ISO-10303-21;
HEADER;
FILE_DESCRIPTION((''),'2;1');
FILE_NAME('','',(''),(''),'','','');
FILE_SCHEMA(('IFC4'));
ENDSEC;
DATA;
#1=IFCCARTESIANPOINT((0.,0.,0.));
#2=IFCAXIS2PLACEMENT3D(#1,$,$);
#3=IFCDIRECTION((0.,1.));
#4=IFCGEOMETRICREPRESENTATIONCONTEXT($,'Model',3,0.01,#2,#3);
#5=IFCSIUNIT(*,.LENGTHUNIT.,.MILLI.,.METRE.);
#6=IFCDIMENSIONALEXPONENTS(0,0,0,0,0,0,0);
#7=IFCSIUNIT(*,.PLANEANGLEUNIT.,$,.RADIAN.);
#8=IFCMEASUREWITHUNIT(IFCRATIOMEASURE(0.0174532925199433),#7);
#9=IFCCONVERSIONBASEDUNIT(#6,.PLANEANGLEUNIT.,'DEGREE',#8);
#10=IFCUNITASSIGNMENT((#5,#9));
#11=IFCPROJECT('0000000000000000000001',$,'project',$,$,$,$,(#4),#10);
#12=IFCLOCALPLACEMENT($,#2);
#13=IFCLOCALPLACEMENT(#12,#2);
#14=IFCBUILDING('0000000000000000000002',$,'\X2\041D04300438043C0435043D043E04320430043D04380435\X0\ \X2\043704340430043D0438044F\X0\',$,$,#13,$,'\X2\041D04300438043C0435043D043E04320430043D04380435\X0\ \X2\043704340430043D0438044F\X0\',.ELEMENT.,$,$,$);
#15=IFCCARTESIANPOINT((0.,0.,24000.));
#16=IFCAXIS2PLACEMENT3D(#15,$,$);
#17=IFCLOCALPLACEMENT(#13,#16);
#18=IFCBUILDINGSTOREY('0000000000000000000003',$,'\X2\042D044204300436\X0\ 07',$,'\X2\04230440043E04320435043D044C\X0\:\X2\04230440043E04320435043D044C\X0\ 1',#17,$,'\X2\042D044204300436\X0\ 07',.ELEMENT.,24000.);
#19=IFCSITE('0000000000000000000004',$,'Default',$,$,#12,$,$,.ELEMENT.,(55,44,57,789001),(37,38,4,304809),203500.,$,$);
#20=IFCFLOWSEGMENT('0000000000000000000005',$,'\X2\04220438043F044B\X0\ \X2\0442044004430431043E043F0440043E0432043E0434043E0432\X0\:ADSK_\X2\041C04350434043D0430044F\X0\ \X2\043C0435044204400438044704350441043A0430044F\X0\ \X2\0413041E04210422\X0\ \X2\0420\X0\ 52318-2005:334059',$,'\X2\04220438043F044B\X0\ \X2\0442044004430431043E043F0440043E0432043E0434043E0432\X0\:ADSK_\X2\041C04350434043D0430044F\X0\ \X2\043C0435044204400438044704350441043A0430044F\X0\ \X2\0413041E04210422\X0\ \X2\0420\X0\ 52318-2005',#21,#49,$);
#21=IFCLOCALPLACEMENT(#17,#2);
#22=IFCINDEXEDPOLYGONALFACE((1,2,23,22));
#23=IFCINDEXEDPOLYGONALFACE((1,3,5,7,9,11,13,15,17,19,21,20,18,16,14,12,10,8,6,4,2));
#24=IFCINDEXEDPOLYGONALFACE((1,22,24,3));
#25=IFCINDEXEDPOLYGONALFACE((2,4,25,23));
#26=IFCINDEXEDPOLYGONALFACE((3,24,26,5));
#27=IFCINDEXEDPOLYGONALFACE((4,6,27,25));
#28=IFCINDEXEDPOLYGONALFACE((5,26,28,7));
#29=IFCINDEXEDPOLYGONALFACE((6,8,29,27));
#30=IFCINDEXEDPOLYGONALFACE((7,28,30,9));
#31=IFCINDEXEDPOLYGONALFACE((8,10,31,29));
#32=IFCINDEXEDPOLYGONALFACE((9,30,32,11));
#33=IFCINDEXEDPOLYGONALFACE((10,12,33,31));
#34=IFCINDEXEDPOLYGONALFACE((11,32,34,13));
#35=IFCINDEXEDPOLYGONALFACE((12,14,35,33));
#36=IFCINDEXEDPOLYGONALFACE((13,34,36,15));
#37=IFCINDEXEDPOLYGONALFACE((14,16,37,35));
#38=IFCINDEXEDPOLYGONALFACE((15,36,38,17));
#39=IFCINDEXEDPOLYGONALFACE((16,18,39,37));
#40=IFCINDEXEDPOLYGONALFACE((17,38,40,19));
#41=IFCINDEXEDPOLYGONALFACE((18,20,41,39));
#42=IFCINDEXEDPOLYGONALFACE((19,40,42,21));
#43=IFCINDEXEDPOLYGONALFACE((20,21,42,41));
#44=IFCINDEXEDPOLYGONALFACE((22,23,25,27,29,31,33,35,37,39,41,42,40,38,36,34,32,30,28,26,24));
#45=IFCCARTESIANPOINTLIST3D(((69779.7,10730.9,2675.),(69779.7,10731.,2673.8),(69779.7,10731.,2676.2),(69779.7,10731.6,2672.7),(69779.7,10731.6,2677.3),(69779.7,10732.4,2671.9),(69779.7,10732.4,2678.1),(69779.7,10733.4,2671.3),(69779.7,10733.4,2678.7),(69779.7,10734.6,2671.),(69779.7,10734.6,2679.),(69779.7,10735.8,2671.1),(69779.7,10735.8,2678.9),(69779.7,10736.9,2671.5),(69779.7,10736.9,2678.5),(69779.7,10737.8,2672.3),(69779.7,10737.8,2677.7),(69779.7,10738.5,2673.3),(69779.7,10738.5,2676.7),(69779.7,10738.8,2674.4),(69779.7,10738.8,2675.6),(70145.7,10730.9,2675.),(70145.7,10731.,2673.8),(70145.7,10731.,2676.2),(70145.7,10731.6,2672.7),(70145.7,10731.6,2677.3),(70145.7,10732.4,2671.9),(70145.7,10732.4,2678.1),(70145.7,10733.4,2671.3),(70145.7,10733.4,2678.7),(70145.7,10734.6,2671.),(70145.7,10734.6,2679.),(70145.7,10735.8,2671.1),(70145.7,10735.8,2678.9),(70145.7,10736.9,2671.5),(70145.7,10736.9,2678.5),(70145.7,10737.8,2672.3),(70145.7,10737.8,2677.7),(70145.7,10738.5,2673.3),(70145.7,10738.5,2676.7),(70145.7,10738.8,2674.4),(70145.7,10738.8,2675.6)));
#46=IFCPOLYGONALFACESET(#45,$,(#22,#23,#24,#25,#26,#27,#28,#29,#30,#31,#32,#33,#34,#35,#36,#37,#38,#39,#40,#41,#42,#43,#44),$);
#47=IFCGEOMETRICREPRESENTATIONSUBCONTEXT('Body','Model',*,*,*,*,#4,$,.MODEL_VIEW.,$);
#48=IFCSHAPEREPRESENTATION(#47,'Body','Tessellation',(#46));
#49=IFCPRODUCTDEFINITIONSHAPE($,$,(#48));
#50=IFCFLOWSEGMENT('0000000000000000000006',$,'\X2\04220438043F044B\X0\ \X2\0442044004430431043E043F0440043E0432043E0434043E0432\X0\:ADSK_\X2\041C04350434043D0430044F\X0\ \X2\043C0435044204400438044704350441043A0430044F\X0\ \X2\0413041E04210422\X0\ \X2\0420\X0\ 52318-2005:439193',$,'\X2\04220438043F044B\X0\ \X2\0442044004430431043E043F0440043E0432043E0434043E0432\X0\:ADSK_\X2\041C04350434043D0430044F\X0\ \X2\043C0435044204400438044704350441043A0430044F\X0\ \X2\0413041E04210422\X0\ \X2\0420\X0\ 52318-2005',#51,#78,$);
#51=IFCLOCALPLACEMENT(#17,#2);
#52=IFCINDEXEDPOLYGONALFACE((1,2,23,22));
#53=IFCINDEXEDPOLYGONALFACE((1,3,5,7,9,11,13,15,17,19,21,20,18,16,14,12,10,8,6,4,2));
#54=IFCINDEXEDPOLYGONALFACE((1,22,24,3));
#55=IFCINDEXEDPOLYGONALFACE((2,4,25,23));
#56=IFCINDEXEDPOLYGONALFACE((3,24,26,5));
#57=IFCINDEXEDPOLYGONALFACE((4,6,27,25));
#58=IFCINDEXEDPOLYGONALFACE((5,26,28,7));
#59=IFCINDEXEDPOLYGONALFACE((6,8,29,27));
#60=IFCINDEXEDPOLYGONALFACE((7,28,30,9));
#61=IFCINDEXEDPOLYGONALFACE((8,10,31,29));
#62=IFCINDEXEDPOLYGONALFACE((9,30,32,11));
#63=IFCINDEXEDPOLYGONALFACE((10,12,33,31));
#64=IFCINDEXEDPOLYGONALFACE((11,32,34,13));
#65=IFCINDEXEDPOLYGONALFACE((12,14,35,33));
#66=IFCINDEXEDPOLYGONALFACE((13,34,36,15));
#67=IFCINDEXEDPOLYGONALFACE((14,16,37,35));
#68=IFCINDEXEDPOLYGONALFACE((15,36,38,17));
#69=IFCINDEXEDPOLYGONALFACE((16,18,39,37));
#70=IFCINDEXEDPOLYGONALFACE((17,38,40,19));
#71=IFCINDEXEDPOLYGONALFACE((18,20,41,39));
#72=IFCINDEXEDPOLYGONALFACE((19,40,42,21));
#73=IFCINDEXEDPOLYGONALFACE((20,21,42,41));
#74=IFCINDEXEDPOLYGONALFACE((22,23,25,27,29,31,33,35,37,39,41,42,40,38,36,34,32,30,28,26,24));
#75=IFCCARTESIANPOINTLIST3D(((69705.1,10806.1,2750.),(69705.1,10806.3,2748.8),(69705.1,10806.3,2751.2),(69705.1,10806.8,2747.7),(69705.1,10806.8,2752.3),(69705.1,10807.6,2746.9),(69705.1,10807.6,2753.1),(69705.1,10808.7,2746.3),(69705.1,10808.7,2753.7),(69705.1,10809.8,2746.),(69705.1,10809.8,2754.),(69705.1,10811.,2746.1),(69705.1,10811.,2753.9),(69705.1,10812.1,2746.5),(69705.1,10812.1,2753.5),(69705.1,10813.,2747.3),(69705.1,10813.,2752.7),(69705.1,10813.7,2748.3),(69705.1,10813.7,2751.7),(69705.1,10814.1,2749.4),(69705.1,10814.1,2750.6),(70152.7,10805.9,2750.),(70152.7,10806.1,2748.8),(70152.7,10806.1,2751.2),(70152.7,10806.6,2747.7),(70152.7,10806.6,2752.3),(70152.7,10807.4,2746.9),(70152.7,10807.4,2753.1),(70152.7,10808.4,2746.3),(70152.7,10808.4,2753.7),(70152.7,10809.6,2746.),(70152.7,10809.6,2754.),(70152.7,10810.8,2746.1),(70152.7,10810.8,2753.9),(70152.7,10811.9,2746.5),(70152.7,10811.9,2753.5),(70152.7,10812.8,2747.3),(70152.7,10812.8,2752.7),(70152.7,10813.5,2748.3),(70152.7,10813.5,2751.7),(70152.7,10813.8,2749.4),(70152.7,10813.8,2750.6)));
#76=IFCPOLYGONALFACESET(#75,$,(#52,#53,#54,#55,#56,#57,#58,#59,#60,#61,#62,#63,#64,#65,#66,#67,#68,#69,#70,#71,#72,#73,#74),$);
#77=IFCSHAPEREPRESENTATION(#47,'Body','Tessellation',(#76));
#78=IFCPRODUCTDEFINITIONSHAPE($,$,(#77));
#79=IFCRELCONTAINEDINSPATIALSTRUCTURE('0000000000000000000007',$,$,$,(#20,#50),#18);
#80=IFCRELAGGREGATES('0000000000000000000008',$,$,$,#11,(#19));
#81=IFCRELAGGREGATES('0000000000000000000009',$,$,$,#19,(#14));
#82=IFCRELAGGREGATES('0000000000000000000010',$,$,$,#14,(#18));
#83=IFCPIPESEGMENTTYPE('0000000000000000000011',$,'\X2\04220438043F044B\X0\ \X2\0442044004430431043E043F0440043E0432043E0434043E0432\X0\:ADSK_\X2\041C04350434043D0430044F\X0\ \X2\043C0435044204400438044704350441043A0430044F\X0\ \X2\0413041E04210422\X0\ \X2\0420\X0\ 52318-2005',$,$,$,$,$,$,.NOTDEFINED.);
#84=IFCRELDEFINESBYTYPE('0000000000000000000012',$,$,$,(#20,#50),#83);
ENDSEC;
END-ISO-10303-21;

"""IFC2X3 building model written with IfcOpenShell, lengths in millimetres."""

from ifc_helpers import new_model, entity, si_unit, converted_unit, direction, frame, origin, origin_2d_with_axis, place, context, subcontext, project, spatial, circle, extrude, type_object, element, save


model = new_model("IFC2X3")

# Units and contexts
model_context = context("Model", 3, precision=0.01, world=origin(), true_north=direction((0.0, 1.0)))
body_context = subcontext(model_context, "Body", "Model", "MODEL_VIEW")
ifc_project = project(units=[si_unit("LENGTHUNIT", "METRE", prefix="MILLI"), converted_unit("PLANEANGLEUNIT", "DEGREE", entity("IfcRatioMeasure", 0.0174532925199433), si_unit("PLANEANGLEUNIT", "RADIAN"), dimensions=[0, 0, 0, 0, 0, 0, 0])], contexts=[model_context])

# Site, building, storey
site_placement = place(None, frame((0.0, 0.0, 0.0)))
site = spatial("IfcSite", under=ifc_project, at=site_placement, Name="Default", CompositionType="ELEMENT", RefLatitude=(55, 44, 57, 789001), RefLongitude=(37, 38, 4, 304809), RefElevation=203500.0)
building_placement = place(site_placement, origin())
building = spatial("IfcBuilding", under=site, at=building_placement, Name="Наименование здания", LongName="Наименование здания", CompositionType="ELEMENT")
storey_placement = place(building_placement, frame((0.0, 0.0, 24000.0)))
storey = spatial("IfcBuildingStorey", under=building, at=storey_placement, Name="Этаж 07", ObjectType="Уровень:Уровень 1", LongName="Этаж 07", CompositionType="ELEMENT", Elevation=24000.0)

# Flow segments
pipe_segment_type = type_object("IfcPipeSegmentType", Name="Типы трубопроводов:ADSK_Медная метрическая ГОСТ Р 52318-2005", PredefinedType="NOTDEFINED")
flow_segment_1_placement = place(storey_placement, frame((69779.7, 10729.3, 2669.4)))
element("IfcFlowSegment", 1, at=flow_segment_1_placement, inside=storey, type_object=pipe_segment_type, Name="Типы трубопроводов:ADSK_Медная метрическая ГОСТ Р 52318-2005:334059", ObjectType="Типы трубопроводов:ADSK_Медная метрическая ГОСТ Р 52318-2005", context=body_context, shape_type="SweptSolid", body=[
    extrude(circle(Radius=4.0, at=origin_2d_with_axis()), frame((0.0, 5.6, 5.6), z_axis=(1.0, -0.000003, 0.0), x_axis=(-0.000003, -1.0, 0.0)), (0.0, 0.0, 1.0), 366.0),
])
flow_segment_2_placement = place(storey_placement, frame((69705.1, 10804.3, 2744.4)))
element("IfcFlowSegment", 2, at=flow_segment_2_placement, inside=storey, type_object=pipe_segment_type, Name="Типы трубопроводов:ADSK_Медная метрическая ГОСТ Р 52318-2005:439193", ObjectType="Типы трубопроводов:ADSK_Медная метрическая ГОСТ Р 52318-2005", context=body_context, shape_type="SweptSolid", body=[
    extrude(circle(Radius=4.0, at=origin_2d_with_axis()), frame((0.0, 5.8, 5.6), z_axis=(1.0, -0.000535, 0.0), x_axis=(-0.000535, -1.0, 0.0)), (0.0, 0.0, 1.0), 447.6),
])

save(model, "model.ifc")
